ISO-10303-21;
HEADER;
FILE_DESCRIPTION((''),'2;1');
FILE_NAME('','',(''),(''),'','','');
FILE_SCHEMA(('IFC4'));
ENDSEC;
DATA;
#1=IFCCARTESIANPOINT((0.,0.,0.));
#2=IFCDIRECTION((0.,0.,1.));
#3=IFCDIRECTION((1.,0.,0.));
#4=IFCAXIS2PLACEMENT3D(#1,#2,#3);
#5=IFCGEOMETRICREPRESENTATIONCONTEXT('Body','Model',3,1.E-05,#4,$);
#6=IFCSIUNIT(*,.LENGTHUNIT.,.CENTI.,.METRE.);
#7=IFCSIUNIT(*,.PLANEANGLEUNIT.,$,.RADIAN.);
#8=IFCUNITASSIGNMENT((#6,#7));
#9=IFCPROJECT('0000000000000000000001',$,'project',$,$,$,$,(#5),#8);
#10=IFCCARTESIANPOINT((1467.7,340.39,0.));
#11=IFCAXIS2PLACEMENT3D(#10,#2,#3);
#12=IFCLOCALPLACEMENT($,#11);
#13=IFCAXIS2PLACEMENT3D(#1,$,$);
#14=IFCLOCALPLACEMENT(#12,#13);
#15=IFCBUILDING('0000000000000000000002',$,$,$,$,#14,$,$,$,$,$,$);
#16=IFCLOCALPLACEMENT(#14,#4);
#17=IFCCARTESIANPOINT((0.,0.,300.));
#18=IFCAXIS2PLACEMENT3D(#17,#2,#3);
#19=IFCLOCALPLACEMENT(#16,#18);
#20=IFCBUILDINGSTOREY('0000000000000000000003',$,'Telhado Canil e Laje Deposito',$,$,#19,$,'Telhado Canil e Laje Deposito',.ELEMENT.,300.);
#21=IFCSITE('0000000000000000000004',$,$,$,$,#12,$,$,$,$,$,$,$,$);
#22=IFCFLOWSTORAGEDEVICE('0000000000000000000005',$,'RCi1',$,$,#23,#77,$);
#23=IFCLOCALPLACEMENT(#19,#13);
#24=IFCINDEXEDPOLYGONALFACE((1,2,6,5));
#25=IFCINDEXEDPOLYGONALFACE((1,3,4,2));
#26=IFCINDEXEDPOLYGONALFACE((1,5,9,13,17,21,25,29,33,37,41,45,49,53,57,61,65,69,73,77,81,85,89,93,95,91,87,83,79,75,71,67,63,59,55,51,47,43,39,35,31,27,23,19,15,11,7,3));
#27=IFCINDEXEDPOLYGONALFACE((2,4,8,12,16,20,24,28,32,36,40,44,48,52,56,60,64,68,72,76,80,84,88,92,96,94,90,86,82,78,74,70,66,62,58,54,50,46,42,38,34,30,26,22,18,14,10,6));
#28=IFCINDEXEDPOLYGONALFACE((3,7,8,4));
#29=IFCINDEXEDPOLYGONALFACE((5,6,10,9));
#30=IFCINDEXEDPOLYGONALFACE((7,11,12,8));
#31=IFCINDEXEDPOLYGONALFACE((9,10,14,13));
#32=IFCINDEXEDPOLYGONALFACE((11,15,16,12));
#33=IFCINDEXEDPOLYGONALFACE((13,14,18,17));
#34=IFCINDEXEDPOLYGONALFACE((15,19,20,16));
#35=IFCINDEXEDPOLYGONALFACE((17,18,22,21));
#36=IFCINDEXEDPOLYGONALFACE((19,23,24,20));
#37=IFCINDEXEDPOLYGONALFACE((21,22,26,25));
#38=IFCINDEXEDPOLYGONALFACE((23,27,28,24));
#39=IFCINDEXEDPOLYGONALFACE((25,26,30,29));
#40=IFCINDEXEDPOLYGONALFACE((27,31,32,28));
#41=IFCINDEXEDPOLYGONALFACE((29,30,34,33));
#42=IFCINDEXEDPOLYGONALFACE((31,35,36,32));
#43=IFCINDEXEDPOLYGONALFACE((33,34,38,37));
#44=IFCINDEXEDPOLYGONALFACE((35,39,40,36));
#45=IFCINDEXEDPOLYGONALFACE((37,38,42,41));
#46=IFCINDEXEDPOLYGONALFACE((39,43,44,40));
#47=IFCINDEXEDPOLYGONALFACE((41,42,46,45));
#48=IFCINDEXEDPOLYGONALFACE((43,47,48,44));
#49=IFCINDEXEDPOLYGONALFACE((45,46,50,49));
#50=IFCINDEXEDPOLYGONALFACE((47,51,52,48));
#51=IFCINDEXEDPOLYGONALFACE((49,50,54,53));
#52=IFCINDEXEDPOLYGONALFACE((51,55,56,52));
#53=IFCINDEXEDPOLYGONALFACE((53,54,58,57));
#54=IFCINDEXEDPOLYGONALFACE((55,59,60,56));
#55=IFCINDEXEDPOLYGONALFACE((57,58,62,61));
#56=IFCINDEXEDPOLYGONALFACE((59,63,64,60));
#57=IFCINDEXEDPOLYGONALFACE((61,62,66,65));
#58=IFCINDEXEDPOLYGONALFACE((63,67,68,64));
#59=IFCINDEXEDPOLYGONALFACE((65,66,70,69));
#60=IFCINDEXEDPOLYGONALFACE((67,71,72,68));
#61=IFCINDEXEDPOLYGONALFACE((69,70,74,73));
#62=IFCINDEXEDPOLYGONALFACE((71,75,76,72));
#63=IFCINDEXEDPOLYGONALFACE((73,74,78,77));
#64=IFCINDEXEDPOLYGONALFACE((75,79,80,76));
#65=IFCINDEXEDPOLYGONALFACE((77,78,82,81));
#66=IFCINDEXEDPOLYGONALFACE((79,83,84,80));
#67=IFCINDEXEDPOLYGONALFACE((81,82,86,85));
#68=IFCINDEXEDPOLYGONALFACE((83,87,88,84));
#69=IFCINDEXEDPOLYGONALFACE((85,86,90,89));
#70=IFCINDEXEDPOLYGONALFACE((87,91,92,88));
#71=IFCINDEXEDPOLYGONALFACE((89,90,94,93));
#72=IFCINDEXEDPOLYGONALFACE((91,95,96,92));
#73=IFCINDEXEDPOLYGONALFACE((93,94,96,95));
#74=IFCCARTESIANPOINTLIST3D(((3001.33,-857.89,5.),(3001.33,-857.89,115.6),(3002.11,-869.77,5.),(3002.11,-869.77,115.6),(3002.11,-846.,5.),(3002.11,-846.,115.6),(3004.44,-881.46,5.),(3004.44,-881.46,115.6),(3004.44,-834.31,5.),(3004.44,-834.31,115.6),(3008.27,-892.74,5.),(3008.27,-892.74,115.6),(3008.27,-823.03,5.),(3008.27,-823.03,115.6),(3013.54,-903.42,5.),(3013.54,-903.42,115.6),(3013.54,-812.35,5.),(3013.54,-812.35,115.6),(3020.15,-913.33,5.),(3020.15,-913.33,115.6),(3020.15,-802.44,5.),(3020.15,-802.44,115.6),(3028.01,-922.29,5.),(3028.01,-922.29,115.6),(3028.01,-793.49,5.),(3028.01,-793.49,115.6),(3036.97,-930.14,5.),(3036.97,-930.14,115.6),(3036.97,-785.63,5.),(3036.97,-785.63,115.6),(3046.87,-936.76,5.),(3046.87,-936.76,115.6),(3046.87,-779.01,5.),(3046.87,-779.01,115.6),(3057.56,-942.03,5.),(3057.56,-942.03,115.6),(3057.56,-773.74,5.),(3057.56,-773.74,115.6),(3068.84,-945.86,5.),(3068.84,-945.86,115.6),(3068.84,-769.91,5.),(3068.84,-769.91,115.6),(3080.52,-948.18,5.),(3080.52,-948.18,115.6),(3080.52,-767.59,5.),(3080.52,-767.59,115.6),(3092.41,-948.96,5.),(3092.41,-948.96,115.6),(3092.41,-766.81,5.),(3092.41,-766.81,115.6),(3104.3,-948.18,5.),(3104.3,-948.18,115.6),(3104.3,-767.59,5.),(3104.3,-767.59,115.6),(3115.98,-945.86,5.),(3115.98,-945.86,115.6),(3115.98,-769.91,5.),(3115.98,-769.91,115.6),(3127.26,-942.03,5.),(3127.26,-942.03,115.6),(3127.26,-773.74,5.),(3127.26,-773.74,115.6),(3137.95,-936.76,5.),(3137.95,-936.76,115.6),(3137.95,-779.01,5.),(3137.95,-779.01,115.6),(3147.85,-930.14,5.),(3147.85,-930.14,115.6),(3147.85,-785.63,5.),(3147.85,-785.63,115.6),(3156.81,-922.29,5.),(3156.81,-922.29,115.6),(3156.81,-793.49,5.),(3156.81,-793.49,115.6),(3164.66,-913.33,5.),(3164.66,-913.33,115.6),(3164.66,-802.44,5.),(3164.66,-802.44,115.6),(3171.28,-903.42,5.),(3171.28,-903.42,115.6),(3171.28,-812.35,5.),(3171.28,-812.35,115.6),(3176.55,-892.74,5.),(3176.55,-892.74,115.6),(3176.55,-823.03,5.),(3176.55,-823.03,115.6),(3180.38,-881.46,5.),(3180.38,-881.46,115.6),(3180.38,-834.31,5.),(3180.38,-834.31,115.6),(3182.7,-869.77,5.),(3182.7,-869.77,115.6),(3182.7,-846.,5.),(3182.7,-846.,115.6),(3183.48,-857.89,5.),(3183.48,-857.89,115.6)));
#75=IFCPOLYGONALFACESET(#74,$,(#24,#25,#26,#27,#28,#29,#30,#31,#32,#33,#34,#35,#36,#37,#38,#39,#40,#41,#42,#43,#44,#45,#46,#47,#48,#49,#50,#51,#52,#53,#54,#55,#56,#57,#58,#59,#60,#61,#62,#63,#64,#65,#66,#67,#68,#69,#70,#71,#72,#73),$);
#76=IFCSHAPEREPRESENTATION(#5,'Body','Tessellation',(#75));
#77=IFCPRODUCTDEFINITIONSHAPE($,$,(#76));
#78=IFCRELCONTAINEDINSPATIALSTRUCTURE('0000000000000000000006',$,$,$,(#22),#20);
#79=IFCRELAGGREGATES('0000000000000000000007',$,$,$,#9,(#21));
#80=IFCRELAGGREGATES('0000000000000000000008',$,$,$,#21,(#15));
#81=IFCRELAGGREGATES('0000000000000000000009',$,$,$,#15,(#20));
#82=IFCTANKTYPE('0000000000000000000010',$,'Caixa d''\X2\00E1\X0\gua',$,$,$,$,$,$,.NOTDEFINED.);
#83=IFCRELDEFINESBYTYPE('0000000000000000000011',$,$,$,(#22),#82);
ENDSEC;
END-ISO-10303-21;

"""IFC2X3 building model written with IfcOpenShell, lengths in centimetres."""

from ifc_helpers import new_model, si_unit, frame, origin, origin_with_axes, origin_2d_with_axis, place, context, project, spatial, circle, extrude, type_object, element, save


model = new_model("IFC2X3")

# Units and contexts
model_context = context("Model", 3, precision=1e-05, world=origin_with_axes(), identifier="Body")
ifc_project = project(units=[si_unit("LENGTHUNIT", "METRE", prefix="CENTI"), si_unit("PLANEANGLEUNIT", "RADIAN")], contexts=[model_context])

# Site, building, storey
site_placement = place(None, frame((1467.7, 340.39, 0.0), z_axis=(0.0, 0.0, 1.0), x_axis=(1.0, 0.0, 0.0)))
site = spatial("IfcSite", under=ifc_project, at=site_placement)
building_placement = place(site_placement, origin())
building = spatial("IfcBuilding", under=site, at=building_placement)
placement = place(building_placement, origin_with_axes())
storey_placement = place(placement, frame((0.0, 0.0, 300.0), z_axis=(0.0, 0.0, 1.0), x_axis=(1.0, 0.0, 0.0)))
storey = spatial("IfcBuildingStorey", under=building, at=storey_placement, Name="Telhado Canil e Laje Deposito", LongName="Telhado Canil e Laje Deposito", CompositionType="ELEMENT", Elevation=300.0)

# Flow storage device
tank_type = type_object("IfcTankType", Name="Caixa d'água")
flow_storage_device_placement = place(storey_placement, frame((3092.41, -857.89, 115.6), z_axis=(0.0, 0.0, 1.0), x_axis=(1.0, 0.0, 0.0)))
element("IfcFlowStorageDevice", 1, at=flow_storage_device_placement, inside=storey, type_object=tank_type, Name="RCi1", context=model_context, shape_type="SolidModel", body=[
    extrude(circle(Radius=91.08, at=origin_2d_with_axis()), frame((0.0, 0.0, 0.0), z_axis=(0.0, 0.0, -1.0), x_axis=(1.0, 0.0, 0.0)), (0.0, 0.0, 1.0), 110.6),
])

save(model, "model.ifc")
